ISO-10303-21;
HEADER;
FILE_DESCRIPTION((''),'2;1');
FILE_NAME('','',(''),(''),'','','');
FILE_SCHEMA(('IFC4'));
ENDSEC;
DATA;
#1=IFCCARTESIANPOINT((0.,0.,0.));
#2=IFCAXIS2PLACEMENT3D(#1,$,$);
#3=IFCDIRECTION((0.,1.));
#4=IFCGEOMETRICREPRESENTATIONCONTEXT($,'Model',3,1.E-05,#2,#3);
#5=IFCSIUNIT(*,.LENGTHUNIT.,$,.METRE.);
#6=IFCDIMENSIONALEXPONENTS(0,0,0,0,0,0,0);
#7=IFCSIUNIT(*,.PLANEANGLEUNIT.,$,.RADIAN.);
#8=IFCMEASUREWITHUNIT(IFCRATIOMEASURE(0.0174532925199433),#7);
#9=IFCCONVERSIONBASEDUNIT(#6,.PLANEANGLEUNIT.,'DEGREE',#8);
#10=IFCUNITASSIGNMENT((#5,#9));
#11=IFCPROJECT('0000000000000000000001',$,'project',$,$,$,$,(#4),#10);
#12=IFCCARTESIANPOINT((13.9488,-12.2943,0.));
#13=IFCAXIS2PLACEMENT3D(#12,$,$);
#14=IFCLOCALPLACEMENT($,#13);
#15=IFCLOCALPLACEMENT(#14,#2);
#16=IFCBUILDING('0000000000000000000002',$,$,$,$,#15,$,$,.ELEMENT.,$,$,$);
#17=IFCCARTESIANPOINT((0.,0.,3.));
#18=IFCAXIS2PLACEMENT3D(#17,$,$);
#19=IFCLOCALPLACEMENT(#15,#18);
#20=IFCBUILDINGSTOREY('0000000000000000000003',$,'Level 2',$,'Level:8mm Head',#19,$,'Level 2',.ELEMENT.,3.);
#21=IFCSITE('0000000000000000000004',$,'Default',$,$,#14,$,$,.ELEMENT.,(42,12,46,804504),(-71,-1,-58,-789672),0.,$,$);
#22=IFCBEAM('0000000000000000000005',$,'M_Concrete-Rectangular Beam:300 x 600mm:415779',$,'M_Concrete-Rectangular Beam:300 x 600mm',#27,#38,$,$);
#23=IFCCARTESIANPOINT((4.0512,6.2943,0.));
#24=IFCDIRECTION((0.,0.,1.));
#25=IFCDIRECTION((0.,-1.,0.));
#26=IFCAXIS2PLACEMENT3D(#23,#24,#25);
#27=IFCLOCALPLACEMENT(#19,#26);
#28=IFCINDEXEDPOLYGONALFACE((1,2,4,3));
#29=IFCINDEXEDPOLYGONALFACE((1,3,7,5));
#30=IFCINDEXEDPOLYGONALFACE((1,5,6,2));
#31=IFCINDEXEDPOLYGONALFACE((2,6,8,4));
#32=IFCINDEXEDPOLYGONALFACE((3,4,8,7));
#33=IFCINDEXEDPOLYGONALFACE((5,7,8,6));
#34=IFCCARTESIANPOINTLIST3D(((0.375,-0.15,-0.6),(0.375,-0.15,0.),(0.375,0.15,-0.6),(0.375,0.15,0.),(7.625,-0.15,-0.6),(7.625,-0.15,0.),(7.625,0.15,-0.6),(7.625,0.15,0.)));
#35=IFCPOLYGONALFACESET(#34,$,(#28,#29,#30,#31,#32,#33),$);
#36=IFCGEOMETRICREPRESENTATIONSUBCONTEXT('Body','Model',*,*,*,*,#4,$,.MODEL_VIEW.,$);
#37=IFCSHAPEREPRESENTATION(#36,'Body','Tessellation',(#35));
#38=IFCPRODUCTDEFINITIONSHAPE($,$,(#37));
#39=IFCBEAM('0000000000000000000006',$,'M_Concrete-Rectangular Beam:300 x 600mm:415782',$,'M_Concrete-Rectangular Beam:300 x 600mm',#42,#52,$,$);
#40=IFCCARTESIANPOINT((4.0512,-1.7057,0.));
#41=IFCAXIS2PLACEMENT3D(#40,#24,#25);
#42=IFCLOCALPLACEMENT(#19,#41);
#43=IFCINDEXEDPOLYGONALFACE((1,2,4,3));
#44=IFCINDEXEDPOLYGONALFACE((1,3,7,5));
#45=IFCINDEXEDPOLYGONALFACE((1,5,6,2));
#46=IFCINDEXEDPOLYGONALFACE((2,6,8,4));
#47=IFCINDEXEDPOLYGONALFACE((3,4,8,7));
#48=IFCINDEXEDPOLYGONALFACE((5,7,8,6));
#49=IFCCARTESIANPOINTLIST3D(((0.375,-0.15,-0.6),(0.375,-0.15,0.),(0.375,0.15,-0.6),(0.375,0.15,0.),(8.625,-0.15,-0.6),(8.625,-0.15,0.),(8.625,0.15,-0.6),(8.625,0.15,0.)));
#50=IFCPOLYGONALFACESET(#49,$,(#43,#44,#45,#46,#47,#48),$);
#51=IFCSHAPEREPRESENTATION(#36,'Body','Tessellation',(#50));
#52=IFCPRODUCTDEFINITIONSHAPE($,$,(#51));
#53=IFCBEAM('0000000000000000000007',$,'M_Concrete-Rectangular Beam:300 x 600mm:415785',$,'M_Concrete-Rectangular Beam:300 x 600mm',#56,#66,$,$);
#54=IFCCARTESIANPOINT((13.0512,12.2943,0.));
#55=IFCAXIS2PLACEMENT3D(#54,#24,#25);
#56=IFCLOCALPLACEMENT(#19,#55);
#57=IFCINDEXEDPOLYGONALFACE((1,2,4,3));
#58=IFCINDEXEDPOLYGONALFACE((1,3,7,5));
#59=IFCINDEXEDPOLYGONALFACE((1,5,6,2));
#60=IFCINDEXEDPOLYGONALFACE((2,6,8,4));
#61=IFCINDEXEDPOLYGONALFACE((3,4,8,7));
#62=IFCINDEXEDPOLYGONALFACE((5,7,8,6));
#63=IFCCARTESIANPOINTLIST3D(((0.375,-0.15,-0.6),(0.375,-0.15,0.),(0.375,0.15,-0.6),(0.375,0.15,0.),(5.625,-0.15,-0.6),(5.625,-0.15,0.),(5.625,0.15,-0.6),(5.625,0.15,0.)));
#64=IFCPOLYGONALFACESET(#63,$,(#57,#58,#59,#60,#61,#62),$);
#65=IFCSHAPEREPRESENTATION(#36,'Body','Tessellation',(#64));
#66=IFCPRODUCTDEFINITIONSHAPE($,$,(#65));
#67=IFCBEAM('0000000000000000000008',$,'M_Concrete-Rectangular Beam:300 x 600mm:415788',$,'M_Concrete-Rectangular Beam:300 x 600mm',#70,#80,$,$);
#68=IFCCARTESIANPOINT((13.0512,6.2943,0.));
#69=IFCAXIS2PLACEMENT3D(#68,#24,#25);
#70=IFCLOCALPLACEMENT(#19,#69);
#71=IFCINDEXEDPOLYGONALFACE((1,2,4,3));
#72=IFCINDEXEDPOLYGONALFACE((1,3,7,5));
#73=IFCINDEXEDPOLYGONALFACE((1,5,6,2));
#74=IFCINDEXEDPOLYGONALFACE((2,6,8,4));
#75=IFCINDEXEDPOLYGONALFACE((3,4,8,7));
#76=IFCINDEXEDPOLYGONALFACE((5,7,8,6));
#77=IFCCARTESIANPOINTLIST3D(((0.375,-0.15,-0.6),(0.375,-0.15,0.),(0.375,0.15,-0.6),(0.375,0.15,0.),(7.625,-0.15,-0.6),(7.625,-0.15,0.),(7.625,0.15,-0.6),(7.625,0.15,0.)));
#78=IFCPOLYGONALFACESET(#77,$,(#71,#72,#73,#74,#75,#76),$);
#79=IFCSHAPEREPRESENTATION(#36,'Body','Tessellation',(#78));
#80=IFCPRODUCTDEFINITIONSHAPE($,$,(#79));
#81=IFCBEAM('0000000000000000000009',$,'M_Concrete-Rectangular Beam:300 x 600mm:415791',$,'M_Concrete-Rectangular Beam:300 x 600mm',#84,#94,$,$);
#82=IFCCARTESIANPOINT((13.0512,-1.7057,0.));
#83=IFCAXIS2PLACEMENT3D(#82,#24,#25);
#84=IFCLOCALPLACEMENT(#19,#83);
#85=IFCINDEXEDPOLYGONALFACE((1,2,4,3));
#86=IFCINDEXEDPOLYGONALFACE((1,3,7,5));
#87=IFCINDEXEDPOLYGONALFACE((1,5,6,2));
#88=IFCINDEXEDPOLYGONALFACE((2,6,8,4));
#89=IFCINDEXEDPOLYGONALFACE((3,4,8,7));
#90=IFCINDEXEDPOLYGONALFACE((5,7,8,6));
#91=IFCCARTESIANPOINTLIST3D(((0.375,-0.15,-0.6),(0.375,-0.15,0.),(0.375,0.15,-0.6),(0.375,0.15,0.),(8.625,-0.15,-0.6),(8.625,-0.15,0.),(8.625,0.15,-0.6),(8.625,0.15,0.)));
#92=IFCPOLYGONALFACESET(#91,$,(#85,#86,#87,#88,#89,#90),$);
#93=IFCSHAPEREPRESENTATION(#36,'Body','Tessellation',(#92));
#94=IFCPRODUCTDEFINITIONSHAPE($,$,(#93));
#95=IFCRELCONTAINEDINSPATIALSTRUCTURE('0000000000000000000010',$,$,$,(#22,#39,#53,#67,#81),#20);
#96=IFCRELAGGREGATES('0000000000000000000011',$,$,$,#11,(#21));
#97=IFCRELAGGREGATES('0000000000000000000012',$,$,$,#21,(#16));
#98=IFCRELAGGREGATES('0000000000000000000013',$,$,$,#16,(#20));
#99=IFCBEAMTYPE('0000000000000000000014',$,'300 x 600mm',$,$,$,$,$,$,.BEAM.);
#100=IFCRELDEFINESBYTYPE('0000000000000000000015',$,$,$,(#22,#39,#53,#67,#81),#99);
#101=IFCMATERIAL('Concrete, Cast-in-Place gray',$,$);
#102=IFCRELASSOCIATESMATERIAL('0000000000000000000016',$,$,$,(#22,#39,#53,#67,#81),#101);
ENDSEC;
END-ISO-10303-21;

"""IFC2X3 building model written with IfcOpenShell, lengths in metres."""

from ifc_helpers import new_model, entity, si_unit, converted_unit, direction, frame, frame_2d, origin, place, context, subcontext, project, spatial, rectangle, extrude, material, type_object, element, save


model = new_model("IFC2X3")

# Units and contexts
model_context = context("Model", 3, precision=1e-05, world=origin(), true_north=direction((0.0, 1.0)))
body_context = subcontext(model_context, "Body", "Model", "MODEL_VIEW")
ifc_project = project(units=[si_unit("LENGTHUNIT", "METRE"), converted_unit("PLANEANGLEUNIT", "DEGREE", entity("IfcRatioMeasure", 0.0174532925199433), si_unit("PLANEANGLEUNIT", "RADIAN"), dimensions=[0, 0, 0, 0, 0, 0, 0])], contexts=[model_context])

# Site, building, storey
site_placement = place(None, frame((13.9488, -12.2943, 0.0)))
site = spatial("IfcSite", under=ifc_project, at=site_placement, Name="Default", CompositionType="ELEMENT", RefLatitude=(42, 12, 46, 804504), RefLongitude=(-71, -1, -58, -789672), RefElevation=0.0)
building_placement = place(site_placement, origin())
building = spatial("IfcBuilding", under=site, at=building_placement, CompositionType="ELEMENT")
storey_placement = place(building_placement, frame((0.0, 0.0, 3.0)))
storey = spatial("IfcBuildingStorey", under=building, at=storey_placement, Name="Level 2", ObjectType="Level:8mm Head", LongName="Level 2", CompositionType="ELEMENT", Elevation=3.0)

# Shared definitions
ifc_material = material(Name="Concrete, Cast-in-Place gray")

# Beams
beam_type_1 = type_object("IfcBeamType", Name="300 x 600mm", PredefinedType="BEAM")
beam_1_placement = place(storey_placement, frame((4.0512, 6.2943, 0.0), z_axis=(0.0, 0.0, 1.0), x_axis=(0.0, -1.0, 0.0)))
element("IfcBeam", 1, at=beam_1_placement, inside=storey, type_object=beam_type_1, material=ifc_material, Name="M_Concrete-Rectangular Beam:300 x 600mm:415779", ObjectType="M_Concrete-Rectangular Beam:300 x 600mm", context=body_context, shape_type="SweptSolid", body=[
    extrude(rectangle(XDim=0.6, YDim=0.3, at=frame_2d((0.0, 0.0), x_axis=(1.0, 0.0))), frame((0.375, 0.0, -0.3), z_axis=(1.0, 0.0, 0.0), x_axis=(0.0, 0.0, -1.0)), (0.0, 0.0, 1.0), 7.25),
])
beam_2_placement = place(storey_placement, frame((4.0512, -1.7057, 0.0), z_axis=(0.0, 0.0, 1.0), x_axis=(0.0, -1.0, 0.0)))
element("IfcBeam", 2, at=beam_2_placement, inside=storey, type_object=beam_type_1, material=ifc_material, Name="M_Concrete-Rectangular Beam:300 x 600mm:415782", ObjectType="M_Concrete-Rectangular Beam:300 x 600mm", context=body_context, shape_type="SweptSolid", body=[
    extrude(rectangle(XDim=0.6, YDim=0.3, at=frame_2d((0.0, 0.0), x_axis=(1.0, 0.0))), frame((0.375, 0.0, -0.3), z_axis=(1.0, 0.0, 0.0), x_axis=(0.0, 0.0, -1.0)), (0.0, 0.0, 1.0), 8.25),
])
beam_3_placement = place(storey_placement, frame((13.0512, 12.2943, 0.0), z_axis=(0.0, 0.0, 1.0), x_axis=(0.0, -1.0, 0.0)))
element("IfcBeam", 3, at=beam_3_placement, inside=storey, type_object=beam_type_1, material=ifc_material, Name="M_Concrete-Rectangular Beam:300 x 600mm:415785", ObjectType="M_Concrete-Rectangular Beam:300 x 600mm", context=body_context, shape_type="SweptSolid", body=[
    extrude(rectangle(XDim=0.6, YDim=0.3, at=frame_2d((0.0, 0.0), x_axis=(1.0, 0.0))), frame((0.375, 0.0, -0.3), z_axis=(1.0, 0.0, 0.0), x_axis=(0.0, 0.0, -1.0)), (0.0, 0.0, 1.0), 5.25),
])
beam_4_placement = place(storey_placement, frame((13.0512, 6.2943, 0.0), z_axis=(0.0, 0.0, 1.0), x_axis=(0.0, -1.0, 0.0)))
element("IfcBeam", 4, at=beam_4_placement, inside=storey, type_object=beam_type_1, material=ifc_material, Name="M_Concrete-Rectangular Beam:300 x 600mm:415788", ObjectType="M_Concrete-Rectangular Beam:300 x 600mm", context=body_context, shape_type="SweptSolid", body=[
    extrude(rectangle(XDim=0.6, YDim=0.3, at=frame_2d((0.0, 0.0), x_axis=(1.0, 0.0))), frame((0.375, 0.0, -0.3), z_axis=(1.0, 0.0, 0.0), x_axis=(0.0, 0.0, -1.0)), (0.0, 0.0, 1.0), 7.25),
])
beam_5_placement = place(storey_placement, frame((13.0512, -1.7057, 0.0), z_axis=(0.0, 0.0, 1.0), x_axis=(0.0, -1.0, 0.0)))
element("IfcBeam", 5, at=beam_5_placement, inside=storey, type_object=beam_type_1, material=ifc_material, Name="M_Concrete-Rectangular Beam:300 x 600mm:415791", ObjectType="M_Concrete-Rectangular Beam:300 x 600mm", context=body_context, shape_type="SweptSolid", body=[
    extrude(rectangle(XDim=0.6, YDim=0.3, at=frame_2d((0.0, 0.0), x_axis=(1.0, 0.0))), frame((0.375, 0.0, -0.3), z_axis=(1.0, 0.0, 0.0), x_axis=(0.0, 0.0, -1.0)), (0.0, 0.0, 1.0), 8.25),
])

save(model, "model.ifc")
